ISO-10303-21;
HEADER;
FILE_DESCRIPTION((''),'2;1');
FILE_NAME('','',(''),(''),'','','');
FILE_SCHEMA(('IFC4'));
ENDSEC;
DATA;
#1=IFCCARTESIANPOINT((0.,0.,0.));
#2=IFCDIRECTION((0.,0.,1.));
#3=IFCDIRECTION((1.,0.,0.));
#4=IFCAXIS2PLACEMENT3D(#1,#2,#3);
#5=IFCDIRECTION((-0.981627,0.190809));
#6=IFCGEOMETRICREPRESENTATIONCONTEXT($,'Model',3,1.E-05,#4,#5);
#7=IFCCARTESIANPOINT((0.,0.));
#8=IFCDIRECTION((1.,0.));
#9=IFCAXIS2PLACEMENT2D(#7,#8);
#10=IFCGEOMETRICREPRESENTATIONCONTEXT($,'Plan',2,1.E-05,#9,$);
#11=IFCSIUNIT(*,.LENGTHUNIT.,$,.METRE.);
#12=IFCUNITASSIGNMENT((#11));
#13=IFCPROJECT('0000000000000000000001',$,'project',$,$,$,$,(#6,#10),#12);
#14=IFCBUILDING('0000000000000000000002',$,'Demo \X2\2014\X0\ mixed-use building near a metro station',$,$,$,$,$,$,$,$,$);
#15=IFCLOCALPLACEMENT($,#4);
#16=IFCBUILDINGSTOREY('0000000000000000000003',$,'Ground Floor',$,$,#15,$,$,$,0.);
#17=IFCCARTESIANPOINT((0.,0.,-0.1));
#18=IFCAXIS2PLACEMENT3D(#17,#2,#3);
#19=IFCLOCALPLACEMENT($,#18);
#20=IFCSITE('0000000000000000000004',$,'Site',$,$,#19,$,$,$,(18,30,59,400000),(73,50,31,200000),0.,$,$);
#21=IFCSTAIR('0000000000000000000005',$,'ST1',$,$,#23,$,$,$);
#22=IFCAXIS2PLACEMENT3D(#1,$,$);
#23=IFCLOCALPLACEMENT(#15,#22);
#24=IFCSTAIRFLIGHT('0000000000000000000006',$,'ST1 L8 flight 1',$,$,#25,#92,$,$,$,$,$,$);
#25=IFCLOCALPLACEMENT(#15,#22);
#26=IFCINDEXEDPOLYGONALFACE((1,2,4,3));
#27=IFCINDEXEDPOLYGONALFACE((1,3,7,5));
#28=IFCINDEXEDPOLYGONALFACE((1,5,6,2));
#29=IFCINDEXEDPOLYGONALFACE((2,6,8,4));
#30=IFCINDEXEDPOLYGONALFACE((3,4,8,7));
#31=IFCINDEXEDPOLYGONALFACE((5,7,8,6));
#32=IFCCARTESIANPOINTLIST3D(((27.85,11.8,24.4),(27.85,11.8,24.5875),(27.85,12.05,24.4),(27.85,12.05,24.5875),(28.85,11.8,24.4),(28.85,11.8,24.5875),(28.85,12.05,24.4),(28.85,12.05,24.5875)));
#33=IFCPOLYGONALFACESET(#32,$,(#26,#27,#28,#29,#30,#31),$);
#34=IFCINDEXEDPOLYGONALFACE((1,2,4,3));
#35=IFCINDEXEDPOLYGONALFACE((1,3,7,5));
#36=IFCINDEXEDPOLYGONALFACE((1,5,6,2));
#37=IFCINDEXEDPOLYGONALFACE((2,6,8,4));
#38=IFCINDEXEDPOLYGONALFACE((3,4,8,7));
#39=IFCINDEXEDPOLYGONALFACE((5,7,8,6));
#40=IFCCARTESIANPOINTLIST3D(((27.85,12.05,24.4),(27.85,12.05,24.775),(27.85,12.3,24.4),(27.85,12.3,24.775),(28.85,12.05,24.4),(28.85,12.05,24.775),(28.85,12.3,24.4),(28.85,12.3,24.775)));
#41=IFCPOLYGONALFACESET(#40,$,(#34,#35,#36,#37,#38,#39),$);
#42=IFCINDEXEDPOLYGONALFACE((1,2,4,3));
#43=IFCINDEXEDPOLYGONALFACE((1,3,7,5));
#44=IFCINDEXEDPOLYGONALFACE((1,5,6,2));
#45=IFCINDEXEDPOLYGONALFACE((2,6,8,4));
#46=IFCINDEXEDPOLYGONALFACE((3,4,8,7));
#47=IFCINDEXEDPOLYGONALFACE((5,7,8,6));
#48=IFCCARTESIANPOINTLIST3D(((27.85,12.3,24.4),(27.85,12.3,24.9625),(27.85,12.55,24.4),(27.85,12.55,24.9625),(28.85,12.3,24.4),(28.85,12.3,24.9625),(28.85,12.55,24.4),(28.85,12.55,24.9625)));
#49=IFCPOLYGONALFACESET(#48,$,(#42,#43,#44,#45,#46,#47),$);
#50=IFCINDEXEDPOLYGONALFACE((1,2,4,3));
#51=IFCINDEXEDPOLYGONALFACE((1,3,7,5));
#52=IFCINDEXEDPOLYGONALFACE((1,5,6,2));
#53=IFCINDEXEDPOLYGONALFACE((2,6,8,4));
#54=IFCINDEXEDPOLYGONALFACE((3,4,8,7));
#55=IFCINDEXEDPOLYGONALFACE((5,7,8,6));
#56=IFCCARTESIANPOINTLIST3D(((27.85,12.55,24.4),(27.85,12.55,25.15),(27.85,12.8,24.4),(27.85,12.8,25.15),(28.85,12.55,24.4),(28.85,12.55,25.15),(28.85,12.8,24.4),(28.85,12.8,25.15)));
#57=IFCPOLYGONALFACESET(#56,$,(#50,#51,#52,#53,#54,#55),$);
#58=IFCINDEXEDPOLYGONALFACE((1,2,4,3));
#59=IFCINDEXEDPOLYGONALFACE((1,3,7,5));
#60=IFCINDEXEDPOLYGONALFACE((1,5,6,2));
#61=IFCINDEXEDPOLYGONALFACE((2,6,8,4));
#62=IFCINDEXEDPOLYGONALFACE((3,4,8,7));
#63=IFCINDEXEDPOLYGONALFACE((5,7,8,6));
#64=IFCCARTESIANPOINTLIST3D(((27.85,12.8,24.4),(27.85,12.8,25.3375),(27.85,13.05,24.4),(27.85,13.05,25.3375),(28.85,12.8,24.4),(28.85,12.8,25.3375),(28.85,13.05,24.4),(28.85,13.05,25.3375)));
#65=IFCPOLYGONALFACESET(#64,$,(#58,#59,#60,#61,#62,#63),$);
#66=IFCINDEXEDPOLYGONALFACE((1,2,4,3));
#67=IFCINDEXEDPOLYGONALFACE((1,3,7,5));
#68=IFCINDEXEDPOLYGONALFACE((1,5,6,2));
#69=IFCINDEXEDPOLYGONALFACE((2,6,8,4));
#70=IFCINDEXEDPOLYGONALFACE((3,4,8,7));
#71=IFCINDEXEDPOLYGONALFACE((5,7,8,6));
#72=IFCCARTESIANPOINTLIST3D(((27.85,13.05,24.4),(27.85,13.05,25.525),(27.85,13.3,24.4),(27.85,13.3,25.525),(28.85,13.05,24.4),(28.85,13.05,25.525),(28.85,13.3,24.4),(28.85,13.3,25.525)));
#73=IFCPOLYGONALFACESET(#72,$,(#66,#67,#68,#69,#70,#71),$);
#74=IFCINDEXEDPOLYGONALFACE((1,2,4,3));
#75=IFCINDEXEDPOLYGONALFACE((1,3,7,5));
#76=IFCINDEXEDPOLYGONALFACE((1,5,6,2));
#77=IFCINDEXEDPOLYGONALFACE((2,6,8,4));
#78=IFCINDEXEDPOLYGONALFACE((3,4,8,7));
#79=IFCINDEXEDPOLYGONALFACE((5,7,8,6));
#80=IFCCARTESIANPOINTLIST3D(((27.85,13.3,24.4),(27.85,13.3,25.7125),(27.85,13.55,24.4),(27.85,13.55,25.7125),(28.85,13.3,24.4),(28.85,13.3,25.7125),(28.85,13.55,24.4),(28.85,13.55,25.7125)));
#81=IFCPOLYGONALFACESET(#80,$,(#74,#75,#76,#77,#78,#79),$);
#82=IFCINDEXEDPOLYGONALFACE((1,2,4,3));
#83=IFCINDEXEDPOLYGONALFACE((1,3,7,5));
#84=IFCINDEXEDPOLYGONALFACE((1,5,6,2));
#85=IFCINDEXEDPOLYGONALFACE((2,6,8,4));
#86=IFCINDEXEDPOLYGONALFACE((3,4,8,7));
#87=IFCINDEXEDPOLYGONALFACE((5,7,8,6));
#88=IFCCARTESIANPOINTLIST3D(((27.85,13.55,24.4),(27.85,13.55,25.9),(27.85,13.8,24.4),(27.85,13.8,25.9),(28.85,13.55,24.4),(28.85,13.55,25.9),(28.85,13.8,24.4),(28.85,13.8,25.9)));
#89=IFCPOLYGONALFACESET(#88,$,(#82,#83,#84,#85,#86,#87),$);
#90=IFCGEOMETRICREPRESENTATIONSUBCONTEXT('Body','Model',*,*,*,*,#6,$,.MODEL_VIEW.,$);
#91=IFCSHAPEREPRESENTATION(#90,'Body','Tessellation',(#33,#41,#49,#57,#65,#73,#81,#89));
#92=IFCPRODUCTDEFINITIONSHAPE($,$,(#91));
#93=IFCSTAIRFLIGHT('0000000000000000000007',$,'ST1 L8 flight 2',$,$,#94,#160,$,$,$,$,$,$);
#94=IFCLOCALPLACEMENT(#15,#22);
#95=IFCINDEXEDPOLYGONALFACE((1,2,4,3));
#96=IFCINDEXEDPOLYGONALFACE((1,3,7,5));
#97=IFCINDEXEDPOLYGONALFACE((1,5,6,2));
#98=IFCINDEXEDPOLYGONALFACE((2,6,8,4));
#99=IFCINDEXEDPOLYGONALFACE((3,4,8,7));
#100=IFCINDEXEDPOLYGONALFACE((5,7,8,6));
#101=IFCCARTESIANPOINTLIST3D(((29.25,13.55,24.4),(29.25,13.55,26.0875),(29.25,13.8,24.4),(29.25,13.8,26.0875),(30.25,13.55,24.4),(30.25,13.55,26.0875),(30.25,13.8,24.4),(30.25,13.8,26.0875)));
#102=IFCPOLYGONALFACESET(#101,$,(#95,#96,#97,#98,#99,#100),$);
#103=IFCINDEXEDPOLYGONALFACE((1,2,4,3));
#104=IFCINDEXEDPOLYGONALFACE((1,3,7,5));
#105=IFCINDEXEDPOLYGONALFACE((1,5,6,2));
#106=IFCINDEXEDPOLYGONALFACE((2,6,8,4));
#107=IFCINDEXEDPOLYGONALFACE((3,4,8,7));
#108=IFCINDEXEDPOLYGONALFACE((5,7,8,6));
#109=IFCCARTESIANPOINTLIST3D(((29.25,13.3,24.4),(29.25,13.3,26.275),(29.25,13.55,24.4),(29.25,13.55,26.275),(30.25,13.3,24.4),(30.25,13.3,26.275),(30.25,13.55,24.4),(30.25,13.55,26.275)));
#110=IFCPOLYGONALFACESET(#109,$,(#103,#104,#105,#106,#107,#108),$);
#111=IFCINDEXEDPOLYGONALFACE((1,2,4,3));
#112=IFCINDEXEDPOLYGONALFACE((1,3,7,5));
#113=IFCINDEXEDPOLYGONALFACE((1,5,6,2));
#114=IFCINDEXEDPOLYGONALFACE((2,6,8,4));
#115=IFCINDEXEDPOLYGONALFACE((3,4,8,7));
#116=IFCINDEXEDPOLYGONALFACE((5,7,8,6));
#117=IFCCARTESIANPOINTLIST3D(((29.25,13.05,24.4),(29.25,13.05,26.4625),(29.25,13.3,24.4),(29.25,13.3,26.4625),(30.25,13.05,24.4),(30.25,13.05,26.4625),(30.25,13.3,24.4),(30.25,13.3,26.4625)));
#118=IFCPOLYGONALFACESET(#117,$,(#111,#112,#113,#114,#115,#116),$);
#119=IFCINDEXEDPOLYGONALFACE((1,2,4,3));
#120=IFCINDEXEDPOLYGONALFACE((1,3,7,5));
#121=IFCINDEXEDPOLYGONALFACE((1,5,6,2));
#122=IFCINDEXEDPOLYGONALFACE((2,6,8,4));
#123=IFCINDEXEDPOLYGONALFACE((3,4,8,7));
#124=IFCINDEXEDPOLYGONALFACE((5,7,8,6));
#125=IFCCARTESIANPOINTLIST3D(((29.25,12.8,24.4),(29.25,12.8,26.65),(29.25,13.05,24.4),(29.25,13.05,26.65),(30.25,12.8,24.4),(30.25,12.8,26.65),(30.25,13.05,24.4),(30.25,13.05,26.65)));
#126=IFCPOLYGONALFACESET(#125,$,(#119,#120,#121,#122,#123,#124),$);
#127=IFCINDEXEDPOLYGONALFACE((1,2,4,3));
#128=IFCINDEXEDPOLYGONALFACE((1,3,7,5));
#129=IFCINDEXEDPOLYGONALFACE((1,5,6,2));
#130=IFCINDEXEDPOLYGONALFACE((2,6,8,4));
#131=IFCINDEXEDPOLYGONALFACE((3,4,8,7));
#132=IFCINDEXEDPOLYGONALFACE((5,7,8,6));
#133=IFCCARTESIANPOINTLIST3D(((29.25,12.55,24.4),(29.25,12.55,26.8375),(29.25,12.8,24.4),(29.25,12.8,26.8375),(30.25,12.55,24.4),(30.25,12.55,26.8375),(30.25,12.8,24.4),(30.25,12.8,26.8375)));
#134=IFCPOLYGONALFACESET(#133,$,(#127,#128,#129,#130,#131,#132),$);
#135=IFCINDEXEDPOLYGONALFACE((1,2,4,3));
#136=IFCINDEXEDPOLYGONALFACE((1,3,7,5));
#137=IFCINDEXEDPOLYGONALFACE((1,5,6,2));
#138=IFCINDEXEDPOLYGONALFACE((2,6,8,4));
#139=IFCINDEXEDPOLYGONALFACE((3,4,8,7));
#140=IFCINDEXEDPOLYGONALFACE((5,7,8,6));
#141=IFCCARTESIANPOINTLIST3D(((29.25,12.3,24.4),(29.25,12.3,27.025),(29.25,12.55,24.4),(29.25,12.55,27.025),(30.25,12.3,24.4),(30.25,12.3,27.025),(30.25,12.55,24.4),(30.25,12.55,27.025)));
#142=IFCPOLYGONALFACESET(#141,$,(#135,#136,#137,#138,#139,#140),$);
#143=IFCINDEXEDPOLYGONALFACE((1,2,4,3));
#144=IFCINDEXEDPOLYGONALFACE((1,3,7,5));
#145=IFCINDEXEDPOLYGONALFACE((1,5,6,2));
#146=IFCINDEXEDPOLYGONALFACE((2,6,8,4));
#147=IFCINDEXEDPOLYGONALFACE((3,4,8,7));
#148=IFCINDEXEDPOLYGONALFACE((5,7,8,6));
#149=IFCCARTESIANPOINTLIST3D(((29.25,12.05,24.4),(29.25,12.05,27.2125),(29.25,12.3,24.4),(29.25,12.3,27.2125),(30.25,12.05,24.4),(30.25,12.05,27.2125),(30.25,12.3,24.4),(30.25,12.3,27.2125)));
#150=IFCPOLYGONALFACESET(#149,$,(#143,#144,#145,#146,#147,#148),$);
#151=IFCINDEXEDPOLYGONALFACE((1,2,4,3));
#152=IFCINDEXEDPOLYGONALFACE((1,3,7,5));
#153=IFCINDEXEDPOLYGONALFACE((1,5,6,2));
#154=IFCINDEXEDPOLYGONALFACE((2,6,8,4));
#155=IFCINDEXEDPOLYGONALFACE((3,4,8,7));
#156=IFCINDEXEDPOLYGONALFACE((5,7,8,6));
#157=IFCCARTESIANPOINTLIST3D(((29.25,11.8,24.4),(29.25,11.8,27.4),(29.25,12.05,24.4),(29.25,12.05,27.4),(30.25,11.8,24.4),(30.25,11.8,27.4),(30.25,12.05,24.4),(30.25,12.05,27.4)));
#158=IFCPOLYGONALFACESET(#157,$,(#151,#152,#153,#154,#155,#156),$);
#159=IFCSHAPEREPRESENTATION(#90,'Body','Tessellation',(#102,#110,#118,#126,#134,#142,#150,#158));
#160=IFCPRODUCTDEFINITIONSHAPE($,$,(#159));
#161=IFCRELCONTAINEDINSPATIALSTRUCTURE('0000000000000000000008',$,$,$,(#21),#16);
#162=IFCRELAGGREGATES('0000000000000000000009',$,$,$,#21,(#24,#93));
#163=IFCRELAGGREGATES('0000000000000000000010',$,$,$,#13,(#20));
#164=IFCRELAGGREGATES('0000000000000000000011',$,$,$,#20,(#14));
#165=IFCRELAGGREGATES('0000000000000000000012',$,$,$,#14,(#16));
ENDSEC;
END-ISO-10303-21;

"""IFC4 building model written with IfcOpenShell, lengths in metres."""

from ifc_helpers import new_model, si_unit, direction, frame, origin_with_axes, origin_2d_with_axis, place, context, subcontext, project, spatial, line, indexed_curve, outline, extrude, element, aggregate, save


model = new_model("IFC4")

# Units and contexts
model_context = context("Model", 3, precision=1e-05, world=origin_with_axes(), true_north=direction((-0.981627, 0.190809)))
plan_context = context("Plan", 2, precision=1e-05, world=origin_2d_with_axis())
body_context = subcontext(model_context, "Body", "Model", "MODEL_VIEW")
ifc_project = project(units=[si_unit("LENGTHUNIT", "METRE")], contexts=[model_context, plan_context])

# Site, building, storey
site_placement = place(None, frame((0.0, 0.0, -0.1), z_axis=(0.0, 0.0, 1.0), x_axis=(1.0, 0.0, 0.0)))
site = spatial("IfcSite", under=ifc_project, at=site_placement, Name="Site", RefLatitude=(18, 30, 59, 400000), RefLongitude=(73, 50, 31, 200000), RefElevation=0.0)
building = spatial("IfcBuilding", under=site, Name="Demo — mixed-use building near a metro station")
storey_placement = place(None, origin_with_axes())
storey = spatial("IfcBuildingStorey", under=building, at=storey_placement, Name="Ground Floor", Elevation=0.0)

# Stair, stair flights
stair = element("IfcStair", 1, inside=storey, Name="ST1")
stair_flight_1_placement = place(None, origin_with_axes())
stair_flight_1 = element("IfcStairFlight", 2, at=stair_flight_1_placement, Name="ST1 L8 flight 1", context=body_context, shape_type="SweptSolid", body=[
    extrude(outline(indexed_curve([(27.85, 11.8), (28.85, 11.8), (28.85, 12.05), (27.85, 12.05)], segments=[line(1, 2, 3, 4, 1)])), frame((0.0, 0.0, 24.4), z_axis=(0.0, 0.0, 1.0), x_axis=(1.0, 0.0, 0.0)), (0.0, 0.0, 1.0), 0.1875),
    extrude(outline(indexed_curve([(27.85, 12.05), (28.85, 12.05), (28.85, 12.3), (27.85, 12.3)], segments=[line(1, 2, 3, 4, 1)])), frame((0.0, 0.0, 24.4), z_axis=(0.0, 0.0, 1.0), x_axis=(1.0, 0.0, 0.0)), (0.0, 0.0, 1.0), 0.375),
    extrude(outline(indexed_curve([(27.85, 12.3), (28.85, 12.3), (28.85, 12.55), (27.85, 12.55)], segments=[line(1, 2, 3, 4, 1)])), frame((0.0, 0.0, 24.4), z_axis=(0.0, 0.0, 1.0), x_axis=(1.0, 0.0, 0.0)), (0.0, 0.0, 1.0), 0.5625),
    extrude(outline(indexed_curve([(27.85, 12.55), (28.85, 12.55), (28.85, 12.8), (27.85, 12.8)], segments=[line(1, 2, 3, 4, 1)])), frame((0.0, 0.0, 24.4), z_axis=(0.0, 0.0, 1.0), x_axis=(1.0, 0.0, 0.0)), (0.0, 0.0, 1.0), 0.75),
    extrude(outline(indexed_curve([(27.85, 12.8), (28.85, 12.8), (28.85, 13.05), (27.85, 13.05)], segments=[line(1, 2, 3, 4, 1)])), frame((0.0, 0.0, 24.4), z_axis=(0.0, 0.0, 1.0), x_axis=(1.0, 0.0, 0.0)), (0.0, 0.0, 1.0), 0.9375),
    extrude(outline(indexed_curve([(27.85, 13.05), (28.85, 13.05), (28.85, 13.3), (27.85, 13.3)], segments=[line(1, 2, 3, 4, 1)])), frame((0.0, 0.0, 24.4), z_axis=(0.0, 0.0, 1.0), x_axis=(1.0, 0.0, 0.0)), (0.0, 0.0, 1.0), 1.125),
    extrude(outline(indexed_curve([(27.85, 13.3), (28.85, 13.3), (28.85, 13.55), (27.85, 13.55)], segments=[line(1, 2, 3, 4, 1)])), frame((0.0, 0.0, 24.4), z_axis=(0.0, 0.0, 1.0), x_axis=(1.0, 0.0, 0.0)), (0.0, 0.0, 1.0), 1.3125),
    extrude(outline(indexed_curve([(27.85, 13.55), (28.85, 13.55), (28.85, 13.8), (27.85, 13.8)], segments=[line(1, 2, 3, 4, 1)])), frame((0.0, 0.0, 24.4), z_axis=(0.0, 0.0, 1.0), x_axis=(1.0, 0.0, 0.0)), (0.0, 0.0, 1.0), 1.5),
])
stair_flight_2_placement = place(None, origin_with_axes())
stair_flight_2 = element("IfcStairFlight", 3, at=stair_flight_2_placement, Name="ST1 L8 flight 2", context=body_context, shape_type="SweptSolid", body=[
    extrude(outline(indexed_curve([(29.25, 13.55), (30.25, 13.55), (30.25, 13.8), (29.25, 13.8)], segments=[line(1, 2, 3, 4, 1)])), frame((0.0, 0.0, 24.4), z_axis=(0.0, 0.0, 1.0), x_axis=(1.0, 0.0, 0.0)), (0.0, 0.0, 1.0), 1.6875),
    extrude(outline(indexed_curve([(29.25, 13.3), (30.25, 13.3), (30.25, 13.55), (29.25, 13.55)], segments=[line(1, 2, 3, 4, 1)])), frame((0.0, 0.0, 24.4), z_axis=(0.0, 0.0, 1.0), x_axis=(1.0, 0.0, 0.0)), (0.0, 0.0, 1.0), 1.875),
    extrude(outline(indexed_curve([(29.25, 13.05), (30.25, 13.05), (30.25, 13.3), (29.25, 13.3)], segments=[line(1, 2, 3, 4, 1)])), frame((0.0, 0.0, 24.4), z_axis=(0.0, 0.0, 1.0), x_axis=(1.0, 0.0, 0.0)), (0.0, 0.0, 1.0), 2.0625),
    extrude(outline(indexed_curve([(29.25, 12.8), (30.25, 12.8), (30.25, 13.05), (29.25, 13.05)], segments=[line(1, 2, 3, 4, 1)])), frame((0.0, 0.0, 24.4), z_axis=(0.0, 0.0, 1.0), x_axis=(1.0, 0.0, 0.0)), (0.0, 0.0, 1.0), 2.25),
    extrude(outline(indexed_curve([(29.25, 12.55), (30.25, 12.55), (30.25, 12.8), (29.25, 12.8)], segments=[line(1, 2, 3, 4, 1)])), frame((0.0, 0.0, 24.4), z_axis=(0.0, 0.0, 1.0), x_axis=(1.0, 0.0, 0.0)), (0.0, 0.0, 1.0), 2.4375),
    extrude(outline(indexed_curve([(29.25, 12.3), (30.25, 12.3), (30.25, 12.55), (29.25, 12.55)], segments=[line(1, 2, 3, 4, 1)])), frame((0.0, 0.0, 24.4), z_axis=(0.0, 0.0, 1.0), x_axis=(1.0, 0.0, 0.0)), (0.0, 0.0, 1.0), 2.625),
    extrude(outline(indexed_curve([(29.25, 12.05), (30.25, 12.05), (30.25, 12.3), (29.25, 12.3)], segments=[line(1, 2, 3, 4, 1)])), frame((0.0, 0.0, 24.4), z_axis=(0.0, 0.0, 1.0), x_axis=(1.0, 0.0, 0.0)), (0.0, 0.0, 1.0), 2.8125),
    extrude(outline(indexed_curve([(29.25, 11.8), (30.25, 11.8), (30.25, 12.05), (29.25, 12.05)], segments=[line(1, 2, 3, 4, 1)])), frame((0.0, 0.0, 24.4), z_axis=(0.0, 0.0, 1.0), x_axis=(1.0, 0.0, 0.0)), (0.0, 0.0, 1.0), 3.0),
])
aggregate(stair, [stair_flight_1, stair_flight_2])

save(model, "model.ifc")
